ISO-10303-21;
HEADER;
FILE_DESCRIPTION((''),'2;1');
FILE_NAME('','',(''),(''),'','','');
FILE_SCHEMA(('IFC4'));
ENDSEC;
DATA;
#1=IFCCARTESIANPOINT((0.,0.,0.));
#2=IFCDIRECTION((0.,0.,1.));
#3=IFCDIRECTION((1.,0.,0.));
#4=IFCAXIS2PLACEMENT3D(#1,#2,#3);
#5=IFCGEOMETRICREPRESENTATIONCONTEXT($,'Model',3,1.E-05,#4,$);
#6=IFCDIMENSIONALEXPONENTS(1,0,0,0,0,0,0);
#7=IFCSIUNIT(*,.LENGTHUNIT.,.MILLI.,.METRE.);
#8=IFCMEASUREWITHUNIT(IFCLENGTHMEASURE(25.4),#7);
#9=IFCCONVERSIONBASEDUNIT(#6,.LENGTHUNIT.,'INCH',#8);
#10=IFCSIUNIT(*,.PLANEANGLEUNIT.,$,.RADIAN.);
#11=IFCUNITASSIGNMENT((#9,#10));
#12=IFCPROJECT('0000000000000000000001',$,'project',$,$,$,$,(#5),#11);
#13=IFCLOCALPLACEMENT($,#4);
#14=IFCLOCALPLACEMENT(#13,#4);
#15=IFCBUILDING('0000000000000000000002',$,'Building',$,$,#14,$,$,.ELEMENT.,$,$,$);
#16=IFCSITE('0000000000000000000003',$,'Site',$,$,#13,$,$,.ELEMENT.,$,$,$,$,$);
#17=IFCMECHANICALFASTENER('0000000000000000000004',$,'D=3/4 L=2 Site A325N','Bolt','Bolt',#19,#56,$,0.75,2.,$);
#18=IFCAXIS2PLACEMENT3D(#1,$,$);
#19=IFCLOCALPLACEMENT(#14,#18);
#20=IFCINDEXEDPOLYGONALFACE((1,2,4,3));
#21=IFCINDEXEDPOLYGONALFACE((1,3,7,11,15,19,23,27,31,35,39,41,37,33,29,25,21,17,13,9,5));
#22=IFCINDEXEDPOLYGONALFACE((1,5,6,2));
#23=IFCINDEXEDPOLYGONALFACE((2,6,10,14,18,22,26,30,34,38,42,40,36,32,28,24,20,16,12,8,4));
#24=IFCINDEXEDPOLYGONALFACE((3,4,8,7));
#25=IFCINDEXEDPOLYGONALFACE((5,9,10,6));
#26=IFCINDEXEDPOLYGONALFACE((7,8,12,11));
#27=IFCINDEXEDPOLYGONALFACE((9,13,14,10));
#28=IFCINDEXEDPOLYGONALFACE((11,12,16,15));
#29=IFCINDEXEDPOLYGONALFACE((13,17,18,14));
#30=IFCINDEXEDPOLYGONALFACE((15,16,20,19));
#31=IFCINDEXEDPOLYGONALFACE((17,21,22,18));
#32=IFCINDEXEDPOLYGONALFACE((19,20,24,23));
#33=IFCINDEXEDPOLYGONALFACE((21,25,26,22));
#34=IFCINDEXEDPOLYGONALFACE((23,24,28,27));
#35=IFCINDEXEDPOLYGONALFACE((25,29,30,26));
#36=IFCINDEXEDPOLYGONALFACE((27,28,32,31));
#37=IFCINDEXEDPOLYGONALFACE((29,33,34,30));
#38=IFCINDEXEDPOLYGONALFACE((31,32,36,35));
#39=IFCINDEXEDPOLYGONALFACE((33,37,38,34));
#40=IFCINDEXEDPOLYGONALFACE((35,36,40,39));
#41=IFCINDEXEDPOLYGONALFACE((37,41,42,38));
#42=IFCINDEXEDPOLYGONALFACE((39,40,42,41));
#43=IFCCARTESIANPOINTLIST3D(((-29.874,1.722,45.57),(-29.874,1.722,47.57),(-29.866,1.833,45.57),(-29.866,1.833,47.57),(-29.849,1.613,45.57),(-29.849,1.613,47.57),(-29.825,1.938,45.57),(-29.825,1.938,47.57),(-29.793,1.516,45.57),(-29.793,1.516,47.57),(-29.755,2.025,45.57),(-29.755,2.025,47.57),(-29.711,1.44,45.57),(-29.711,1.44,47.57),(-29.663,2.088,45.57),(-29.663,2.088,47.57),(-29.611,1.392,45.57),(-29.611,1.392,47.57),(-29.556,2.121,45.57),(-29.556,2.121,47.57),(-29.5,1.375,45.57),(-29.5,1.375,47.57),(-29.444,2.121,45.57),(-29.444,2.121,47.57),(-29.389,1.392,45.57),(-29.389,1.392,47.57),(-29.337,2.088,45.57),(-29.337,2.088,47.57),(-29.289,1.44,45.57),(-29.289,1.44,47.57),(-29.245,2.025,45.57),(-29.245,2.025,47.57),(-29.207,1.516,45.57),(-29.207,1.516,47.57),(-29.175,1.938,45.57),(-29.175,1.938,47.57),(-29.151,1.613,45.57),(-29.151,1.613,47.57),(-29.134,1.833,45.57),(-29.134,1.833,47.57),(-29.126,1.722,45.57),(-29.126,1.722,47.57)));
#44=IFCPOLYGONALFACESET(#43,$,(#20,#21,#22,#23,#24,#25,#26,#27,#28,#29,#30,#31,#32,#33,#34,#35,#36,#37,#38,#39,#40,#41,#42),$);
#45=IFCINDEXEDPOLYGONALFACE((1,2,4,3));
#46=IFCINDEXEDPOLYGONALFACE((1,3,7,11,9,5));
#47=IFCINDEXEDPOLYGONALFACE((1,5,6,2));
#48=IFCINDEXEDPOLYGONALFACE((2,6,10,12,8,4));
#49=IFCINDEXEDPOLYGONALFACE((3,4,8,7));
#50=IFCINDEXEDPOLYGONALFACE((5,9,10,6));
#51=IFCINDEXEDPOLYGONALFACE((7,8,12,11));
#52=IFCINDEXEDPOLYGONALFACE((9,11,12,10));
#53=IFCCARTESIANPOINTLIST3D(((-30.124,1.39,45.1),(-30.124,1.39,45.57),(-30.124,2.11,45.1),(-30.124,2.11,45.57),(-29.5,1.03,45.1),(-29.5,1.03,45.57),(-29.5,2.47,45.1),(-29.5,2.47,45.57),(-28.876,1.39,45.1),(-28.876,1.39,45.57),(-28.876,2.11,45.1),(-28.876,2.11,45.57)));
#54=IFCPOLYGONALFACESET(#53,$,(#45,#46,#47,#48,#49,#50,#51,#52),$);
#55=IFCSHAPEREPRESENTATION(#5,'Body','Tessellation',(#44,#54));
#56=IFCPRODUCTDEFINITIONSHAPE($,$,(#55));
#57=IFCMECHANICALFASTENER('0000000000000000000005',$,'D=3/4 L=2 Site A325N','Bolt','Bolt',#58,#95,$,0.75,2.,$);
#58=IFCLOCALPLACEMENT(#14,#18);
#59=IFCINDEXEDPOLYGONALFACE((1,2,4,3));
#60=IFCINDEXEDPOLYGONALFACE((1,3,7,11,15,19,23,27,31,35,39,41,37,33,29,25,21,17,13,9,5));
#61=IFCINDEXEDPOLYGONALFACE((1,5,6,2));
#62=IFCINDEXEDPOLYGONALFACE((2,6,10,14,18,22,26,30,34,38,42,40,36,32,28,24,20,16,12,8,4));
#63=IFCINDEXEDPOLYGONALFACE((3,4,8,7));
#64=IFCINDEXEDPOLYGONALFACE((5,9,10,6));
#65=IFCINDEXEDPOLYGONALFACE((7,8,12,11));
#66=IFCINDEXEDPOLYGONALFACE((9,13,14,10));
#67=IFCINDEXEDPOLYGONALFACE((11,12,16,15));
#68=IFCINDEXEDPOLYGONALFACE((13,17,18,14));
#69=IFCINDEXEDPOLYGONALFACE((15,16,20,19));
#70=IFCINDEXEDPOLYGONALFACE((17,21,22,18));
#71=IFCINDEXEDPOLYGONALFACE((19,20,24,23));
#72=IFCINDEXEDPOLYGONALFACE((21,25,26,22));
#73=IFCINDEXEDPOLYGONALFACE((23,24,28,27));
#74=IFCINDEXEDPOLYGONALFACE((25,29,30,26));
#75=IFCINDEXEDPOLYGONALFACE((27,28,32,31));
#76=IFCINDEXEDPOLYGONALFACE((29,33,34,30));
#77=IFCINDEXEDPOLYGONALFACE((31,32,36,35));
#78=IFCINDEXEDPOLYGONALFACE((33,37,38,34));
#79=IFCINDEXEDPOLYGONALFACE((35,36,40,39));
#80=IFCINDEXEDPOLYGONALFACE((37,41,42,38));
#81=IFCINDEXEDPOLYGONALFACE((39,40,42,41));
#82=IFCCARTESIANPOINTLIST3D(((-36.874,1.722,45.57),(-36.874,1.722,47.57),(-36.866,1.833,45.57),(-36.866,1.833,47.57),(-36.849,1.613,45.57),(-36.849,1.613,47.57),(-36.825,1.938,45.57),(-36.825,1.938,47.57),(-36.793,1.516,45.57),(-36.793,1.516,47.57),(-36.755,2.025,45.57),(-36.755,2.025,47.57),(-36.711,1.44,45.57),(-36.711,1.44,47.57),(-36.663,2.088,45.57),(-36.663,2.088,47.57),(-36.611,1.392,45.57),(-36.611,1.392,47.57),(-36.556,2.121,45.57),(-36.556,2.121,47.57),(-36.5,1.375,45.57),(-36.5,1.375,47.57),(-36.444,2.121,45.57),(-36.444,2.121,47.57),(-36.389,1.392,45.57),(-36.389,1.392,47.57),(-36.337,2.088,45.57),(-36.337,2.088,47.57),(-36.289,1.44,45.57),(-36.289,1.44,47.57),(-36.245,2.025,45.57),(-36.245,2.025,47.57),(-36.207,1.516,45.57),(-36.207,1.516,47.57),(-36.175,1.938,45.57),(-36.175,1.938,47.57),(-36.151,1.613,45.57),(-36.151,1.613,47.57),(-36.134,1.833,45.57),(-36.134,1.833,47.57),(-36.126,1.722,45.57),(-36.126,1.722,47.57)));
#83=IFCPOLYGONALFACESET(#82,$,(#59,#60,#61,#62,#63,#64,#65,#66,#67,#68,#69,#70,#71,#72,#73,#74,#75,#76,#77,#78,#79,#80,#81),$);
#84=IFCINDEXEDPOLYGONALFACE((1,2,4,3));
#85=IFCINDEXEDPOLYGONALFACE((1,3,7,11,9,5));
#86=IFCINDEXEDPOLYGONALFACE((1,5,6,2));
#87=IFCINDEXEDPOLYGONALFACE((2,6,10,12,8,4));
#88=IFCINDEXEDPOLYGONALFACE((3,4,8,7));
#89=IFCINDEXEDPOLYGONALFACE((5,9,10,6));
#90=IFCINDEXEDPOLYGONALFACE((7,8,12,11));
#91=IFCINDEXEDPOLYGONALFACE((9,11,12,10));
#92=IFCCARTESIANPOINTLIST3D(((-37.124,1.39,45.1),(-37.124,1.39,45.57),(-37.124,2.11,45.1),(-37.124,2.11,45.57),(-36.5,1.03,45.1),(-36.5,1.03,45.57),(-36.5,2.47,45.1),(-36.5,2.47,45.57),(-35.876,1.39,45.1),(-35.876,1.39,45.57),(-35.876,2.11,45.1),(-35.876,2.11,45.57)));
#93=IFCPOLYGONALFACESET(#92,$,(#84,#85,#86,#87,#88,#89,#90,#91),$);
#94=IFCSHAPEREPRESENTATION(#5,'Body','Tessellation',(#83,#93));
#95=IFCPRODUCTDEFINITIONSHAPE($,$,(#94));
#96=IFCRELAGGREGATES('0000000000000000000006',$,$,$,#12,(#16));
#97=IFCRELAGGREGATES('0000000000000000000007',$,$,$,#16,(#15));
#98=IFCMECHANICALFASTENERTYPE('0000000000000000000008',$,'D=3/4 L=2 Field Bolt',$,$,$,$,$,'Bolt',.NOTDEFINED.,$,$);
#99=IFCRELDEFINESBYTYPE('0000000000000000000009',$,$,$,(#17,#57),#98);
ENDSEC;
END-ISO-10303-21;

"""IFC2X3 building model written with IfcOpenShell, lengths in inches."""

from ifc_helpers import new_model, entity, si_unit, converted_unit, frame, origin_with_axes, origin_2d_with_axis, place, context, project, spatial, polyline, circle, outline, extrude, source, transform, mapped, type_object, type_shapes, element, save


model = new_model("IFC2X3")

# Units and contexts
model_context = context("Model", 3, precision=1e-05, world=origin_with_axes())
ifc_project = project(units=[converted_unit("LENGTHUNIT", "INCH", entity("IfcLengthMeasure", 25.4), si_unit("LENGTHUNIT", "METRE", prefix="MILLI"), dimensions=[1, 0, 0, 0, 0, 0, 0]), si_unit("PLANEANGLEUNIT", "RADIAN")], contexts=[model_context])

# Site, building
site_placement = place(None, origin_with_axes())
site = spatial("IfcSite", under=ifc_project, at=site_placement, Name="Site", CompositionType="ELEMENT")
building_placement = place(site_placement, origin_with_axes())
building = spatial("IfcBuilding", under=site, at=building_placement, Name="Building", CompositionType="ELEMENT")

# Mechanical fasteners
mechanical_fastener_type_1 = type_object("IfcMechanicalFastenerType", Name="D=3/4 L=2 Field Bolt", ElementType="Bolt")
shared_shape_1 = source(origin_with_axes(), model_context, "Body", "SweptSolid", [
    extrude(circle(Radius=0.375, at=origin_2d_with_axis()), frame((0.0, 0.0, 0.0), z_axis=(1.0, 0.0, 0.0), x_axis=(0.0, 1.0, 0.0)), (0.0, 0.0, 1.0), 2.0),
    extrude(outline(polyline([(-0.72, 0.0), (-0.36, 0.624), (0.36, 0.624), (0.72, 0.0), (0.36, -0.624), (-0.36, -0.624), (-0.72, 0.0)])), frame((0.0, 0.0, 0.0), z_axis=(1.0, 0.0, 0.0), x_axis=(0.0, 1.0, 0.0)), (0.0, 0.0, -1.0), 0.47),
])
type_shapes(mechanical_fastener_type_1, [shared_shape_1])
placement_1 = place(building_placement, frame((-33.0, 0.0, 46.0), z_axis=(-1.0, 0.0, 0.0), x_axis=(0.0, 0.0, 1.0)))
placement_2 = place(placement_1, frame((-0.43, 1.75, 3.5), z_axis=(0.0, 0.0, -1.0), x_axis=(1.0, 0.0, 0.0)))
for number, where, z_axis, x_axis, name in (
    (1, (0.0, 0.0, 7.0), (0.0, 0.0, 1.0), (1.0, 0.0, 0.0), "D=3/4 L=2 Site A325N"),
    (2, (0.0, 0.0, 0.0), (0.0, 0.0, 1.0), (1.0, 0.0, 0.0), "D=3/4 L=2 Site A325N"),
):
    element("IfcMechanicalFastener", number, at=place(placement_2, frame(where, z_axis=z_axis, x_axis=x_axis)), type_object=mechanical_fastener_type_1, Name=name, Description="Bolt", ObjectType="Bolt", NominalDiameter=0.75, NominalLength=2.0, context=model_context, shape_type="MappedRepresentation", body=[
        mapped(shared_shape_1, transform((0.0, 0.0, 0.0), scale=1.0)),
    ])

save(model, "model.ifc")
